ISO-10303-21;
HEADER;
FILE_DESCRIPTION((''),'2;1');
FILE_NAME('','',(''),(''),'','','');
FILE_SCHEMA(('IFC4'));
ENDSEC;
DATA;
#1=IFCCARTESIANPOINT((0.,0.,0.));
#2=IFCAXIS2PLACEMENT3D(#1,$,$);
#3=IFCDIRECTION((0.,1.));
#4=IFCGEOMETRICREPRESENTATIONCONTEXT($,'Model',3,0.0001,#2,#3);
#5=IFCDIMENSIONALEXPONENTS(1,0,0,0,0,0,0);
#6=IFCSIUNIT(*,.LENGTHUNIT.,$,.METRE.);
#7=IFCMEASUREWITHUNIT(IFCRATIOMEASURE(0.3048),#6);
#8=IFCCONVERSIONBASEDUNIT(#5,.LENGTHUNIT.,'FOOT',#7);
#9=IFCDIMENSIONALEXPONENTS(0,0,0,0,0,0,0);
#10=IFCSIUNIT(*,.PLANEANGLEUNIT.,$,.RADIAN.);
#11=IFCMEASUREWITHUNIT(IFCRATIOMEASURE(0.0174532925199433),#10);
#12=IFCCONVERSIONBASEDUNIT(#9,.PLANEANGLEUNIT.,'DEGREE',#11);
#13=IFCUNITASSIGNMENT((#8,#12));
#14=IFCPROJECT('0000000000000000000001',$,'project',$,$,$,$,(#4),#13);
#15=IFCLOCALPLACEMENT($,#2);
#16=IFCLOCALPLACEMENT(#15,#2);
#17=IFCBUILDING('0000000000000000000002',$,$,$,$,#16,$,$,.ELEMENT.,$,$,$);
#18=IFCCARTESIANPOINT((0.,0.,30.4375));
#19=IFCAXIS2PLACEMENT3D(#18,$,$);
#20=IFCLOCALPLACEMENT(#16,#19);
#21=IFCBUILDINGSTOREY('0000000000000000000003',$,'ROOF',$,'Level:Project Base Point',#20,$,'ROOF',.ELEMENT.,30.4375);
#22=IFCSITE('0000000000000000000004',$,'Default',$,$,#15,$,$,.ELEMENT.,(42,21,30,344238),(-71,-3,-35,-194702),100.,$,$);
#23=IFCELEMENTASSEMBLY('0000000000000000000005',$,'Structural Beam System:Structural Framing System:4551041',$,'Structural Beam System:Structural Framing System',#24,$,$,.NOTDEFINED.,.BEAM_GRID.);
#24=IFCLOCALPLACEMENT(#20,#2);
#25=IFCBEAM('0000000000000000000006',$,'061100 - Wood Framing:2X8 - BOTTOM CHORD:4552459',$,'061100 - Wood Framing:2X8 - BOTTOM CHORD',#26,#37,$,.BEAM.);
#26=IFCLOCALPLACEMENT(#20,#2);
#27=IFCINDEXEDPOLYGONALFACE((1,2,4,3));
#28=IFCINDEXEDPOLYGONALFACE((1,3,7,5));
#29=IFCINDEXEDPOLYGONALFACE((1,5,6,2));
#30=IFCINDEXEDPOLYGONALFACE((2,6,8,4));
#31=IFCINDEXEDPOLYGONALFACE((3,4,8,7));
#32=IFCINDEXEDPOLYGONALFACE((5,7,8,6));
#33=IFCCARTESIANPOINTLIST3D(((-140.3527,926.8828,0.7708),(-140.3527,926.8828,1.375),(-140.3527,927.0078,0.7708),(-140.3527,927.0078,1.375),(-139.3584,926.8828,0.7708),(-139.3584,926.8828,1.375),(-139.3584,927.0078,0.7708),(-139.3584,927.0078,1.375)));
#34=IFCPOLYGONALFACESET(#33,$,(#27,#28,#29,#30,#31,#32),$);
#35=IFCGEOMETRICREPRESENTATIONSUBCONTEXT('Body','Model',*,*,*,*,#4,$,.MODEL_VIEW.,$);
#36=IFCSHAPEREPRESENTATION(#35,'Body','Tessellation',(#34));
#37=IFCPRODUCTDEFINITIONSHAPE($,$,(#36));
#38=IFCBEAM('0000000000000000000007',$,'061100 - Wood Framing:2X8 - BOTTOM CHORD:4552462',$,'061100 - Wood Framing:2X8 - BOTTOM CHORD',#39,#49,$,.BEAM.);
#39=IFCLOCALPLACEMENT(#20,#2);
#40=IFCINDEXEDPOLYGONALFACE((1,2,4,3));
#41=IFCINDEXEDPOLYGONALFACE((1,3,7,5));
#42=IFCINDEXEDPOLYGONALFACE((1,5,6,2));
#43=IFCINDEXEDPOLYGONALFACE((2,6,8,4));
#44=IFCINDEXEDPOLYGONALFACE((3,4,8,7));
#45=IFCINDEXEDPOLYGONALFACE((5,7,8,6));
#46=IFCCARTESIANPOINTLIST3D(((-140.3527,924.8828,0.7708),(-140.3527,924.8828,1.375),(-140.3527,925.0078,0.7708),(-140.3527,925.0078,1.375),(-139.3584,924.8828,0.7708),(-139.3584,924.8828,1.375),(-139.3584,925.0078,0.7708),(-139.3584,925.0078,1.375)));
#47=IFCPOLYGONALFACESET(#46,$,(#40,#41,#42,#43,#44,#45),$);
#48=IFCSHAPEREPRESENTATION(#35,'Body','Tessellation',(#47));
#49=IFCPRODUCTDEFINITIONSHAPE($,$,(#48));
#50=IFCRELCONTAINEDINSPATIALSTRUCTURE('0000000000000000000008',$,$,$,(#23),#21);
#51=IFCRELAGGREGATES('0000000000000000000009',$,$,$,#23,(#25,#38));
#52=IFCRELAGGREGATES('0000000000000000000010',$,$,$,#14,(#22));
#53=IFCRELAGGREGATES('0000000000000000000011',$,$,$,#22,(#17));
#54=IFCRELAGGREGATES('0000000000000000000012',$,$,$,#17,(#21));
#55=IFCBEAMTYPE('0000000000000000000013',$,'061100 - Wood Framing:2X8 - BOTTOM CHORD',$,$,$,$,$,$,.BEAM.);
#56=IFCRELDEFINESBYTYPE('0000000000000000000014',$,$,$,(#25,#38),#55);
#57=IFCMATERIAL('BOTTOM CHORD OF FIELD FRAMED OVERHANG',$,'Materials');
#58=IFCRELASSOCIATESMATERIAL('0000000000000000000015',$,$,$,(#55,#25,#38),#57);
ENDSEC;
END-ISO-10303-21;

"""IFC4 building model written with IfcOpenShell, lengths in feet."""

from ifc_helpers import new_model, entity, si_unit, converted_unit, direction, frame, origin, origin_2d_with_axis, place, context, subcontext, project, spatial, rectangle, extrude, source, transform, mapped, material, material_profile, profile_set, profile_usage, type_object, type_shapes, element, aggregate, save


model = new_model("IFC4")

# Units and contexts
model_context = context("Model", 3, precision=0.0001, world=origin(), true_north=direction((0.0, 1.0)))
body_context = subcontext(model_context, "Body", "Model", "MODEL_VIEW")
ifc_project = project(units=[converted_unit("LENGTHUNIT", "FOOT", entity("IfcRatioMeasure", 0.3048), si_unit("LENGTHUNIT", "METRE"), dimensions=[1, 0, 0, 0, 0, 0, 0]), converted_unit("PLANEANGLEUNIT", "DEGREE", entity("IfcRatioMeasure", 0.0174532925199433), si_unit("PLANEANGLEUNIT", "RADIAN"), dimensions=[0, 0, 0, 0, 0, 0, 0])], contexts=[model_context])

# Site, building, storey
site_placement = place(None, origin())
site = spatial("IfcSite", under=ifc_project, at=site_placement, Name="Default", CompositionType="ELEMENT", RefLatitude=(42, 21, 30, 344238), RefLongitude=(-71, -3, -35, -194702), RefElevation=100.0)
building_placement = place(site_placement, origin())
building = spatial("IfcBuilding", under=site, at=building_placement, CompositionType="ELEMENT")
storey_placement = place(building_placement, frame((0.0, 0.0, 30.4375)))
storey = spatial("IfcBuildingStorey", under=building, at=storey_placement, Name="ROOF", ObjectType="Level:Project Base Point", LongName="ROOF", CompositionType="ELEMENT", Elevation=30.4375)

# Element assembly, beams
ifc_material_1 = material(Name="BOTTOM CHORD OF FIELD FRAMED OVERHANG", Category="Materials")
ifc_material_profile_1 = material_profile(ifc_material_1, rectangle(XDim=0.6042, YDim=0.125, at=origin_2d_with_axis()), Name="2X8 - BOTTOM CHORD")
ifc_profile_set_1 = profile_set([ifc_material_profile_1], Name="2X8 - BOTTOM CHORD")
assembly_1_placement = place(storey_placement, origin())
assembly_1 = element("IfcElementAssembly", 1, at=assembly_1_placement, inside=storey, Name="Structural Beam System:Structural Framing System:4551041", ObjectType="Structural Beam System:Structural Framing System", AssemblyPlace="NOTDEFINED", PredefinedType="BEAM_GRID")
beam_type_1 = type_object("IfcBeamType", Name="061100 - Wood Framing:2X8 - BOTTOM CHORD", PredefinedType="BEAM", material=ifc_profile_set_1)
shared_shape_1 = source(origin(), body_context, "Body", "SweptSolid", [
    extrude(rectangle(XDim=0.6042, YDim=0.125, at=origin_2d_with_axis()), frame((-0.4972, 0.0, 0.0), z_axis=(1.0, 0.0, 0.0), x_axis=(0.0, 0.0, -1.0)), (0.0, 0.0, 1.0), 0.9944),
])
type_shapes(beam_type_1, [shared_shape_1])
ifc_profile_usage_1 = profile_usage(ifc_profile_set_1, cardinal=8)
beam_1_placement = place(assembly_1_placement, frame((-139.8556, 926.9453, 1.0729)))
beam_1 = element("IfcBeam", 2, at=beam_1_placement, type_object=beam_type_1, material=ifc_profile_usage_1, Name="061100 - Wood Framing:2X8 - BOTTOM CHORD:4552459", ObjectType="061100 - Wood Framing:2X8 - BOTTOM CHORD", PredefinedType="BEAM", context=body_context, shape_type="MappedRepresentation", body=[
    mapped(shared_shape_1, transform((0.0, 0.0, 0.0), scale=1.0)),
])
ifc_profile_usage_2 = profile_usage(ifc_profile_set_1, cardinal=8)
beam_2_placement = place(assembly_1_placement, frame((-139.8556, 924.9453, 1.0729)))
beam_2 = element("IfcBeam", 3, at=beam_2_placement, type_object=beam_type_1, material=ifc_profile_usage_2, Name="061100 - Wood Framing:2X8 - BOTTOM CHORD:4552462", ObjectType="061100 - Wood Framing:2X8 - BOTTOM CHORD", PredefinedType="BEAM", context=body_context, shape_type="MappedRepresentation", body=[
    mapped(shared_shape_1, transform((0.0, 0.0, 0.0), scale=1.0)),
])
aggregate(assembly_1, [beam_1, beam_2])

save(model, "model.ifc")
